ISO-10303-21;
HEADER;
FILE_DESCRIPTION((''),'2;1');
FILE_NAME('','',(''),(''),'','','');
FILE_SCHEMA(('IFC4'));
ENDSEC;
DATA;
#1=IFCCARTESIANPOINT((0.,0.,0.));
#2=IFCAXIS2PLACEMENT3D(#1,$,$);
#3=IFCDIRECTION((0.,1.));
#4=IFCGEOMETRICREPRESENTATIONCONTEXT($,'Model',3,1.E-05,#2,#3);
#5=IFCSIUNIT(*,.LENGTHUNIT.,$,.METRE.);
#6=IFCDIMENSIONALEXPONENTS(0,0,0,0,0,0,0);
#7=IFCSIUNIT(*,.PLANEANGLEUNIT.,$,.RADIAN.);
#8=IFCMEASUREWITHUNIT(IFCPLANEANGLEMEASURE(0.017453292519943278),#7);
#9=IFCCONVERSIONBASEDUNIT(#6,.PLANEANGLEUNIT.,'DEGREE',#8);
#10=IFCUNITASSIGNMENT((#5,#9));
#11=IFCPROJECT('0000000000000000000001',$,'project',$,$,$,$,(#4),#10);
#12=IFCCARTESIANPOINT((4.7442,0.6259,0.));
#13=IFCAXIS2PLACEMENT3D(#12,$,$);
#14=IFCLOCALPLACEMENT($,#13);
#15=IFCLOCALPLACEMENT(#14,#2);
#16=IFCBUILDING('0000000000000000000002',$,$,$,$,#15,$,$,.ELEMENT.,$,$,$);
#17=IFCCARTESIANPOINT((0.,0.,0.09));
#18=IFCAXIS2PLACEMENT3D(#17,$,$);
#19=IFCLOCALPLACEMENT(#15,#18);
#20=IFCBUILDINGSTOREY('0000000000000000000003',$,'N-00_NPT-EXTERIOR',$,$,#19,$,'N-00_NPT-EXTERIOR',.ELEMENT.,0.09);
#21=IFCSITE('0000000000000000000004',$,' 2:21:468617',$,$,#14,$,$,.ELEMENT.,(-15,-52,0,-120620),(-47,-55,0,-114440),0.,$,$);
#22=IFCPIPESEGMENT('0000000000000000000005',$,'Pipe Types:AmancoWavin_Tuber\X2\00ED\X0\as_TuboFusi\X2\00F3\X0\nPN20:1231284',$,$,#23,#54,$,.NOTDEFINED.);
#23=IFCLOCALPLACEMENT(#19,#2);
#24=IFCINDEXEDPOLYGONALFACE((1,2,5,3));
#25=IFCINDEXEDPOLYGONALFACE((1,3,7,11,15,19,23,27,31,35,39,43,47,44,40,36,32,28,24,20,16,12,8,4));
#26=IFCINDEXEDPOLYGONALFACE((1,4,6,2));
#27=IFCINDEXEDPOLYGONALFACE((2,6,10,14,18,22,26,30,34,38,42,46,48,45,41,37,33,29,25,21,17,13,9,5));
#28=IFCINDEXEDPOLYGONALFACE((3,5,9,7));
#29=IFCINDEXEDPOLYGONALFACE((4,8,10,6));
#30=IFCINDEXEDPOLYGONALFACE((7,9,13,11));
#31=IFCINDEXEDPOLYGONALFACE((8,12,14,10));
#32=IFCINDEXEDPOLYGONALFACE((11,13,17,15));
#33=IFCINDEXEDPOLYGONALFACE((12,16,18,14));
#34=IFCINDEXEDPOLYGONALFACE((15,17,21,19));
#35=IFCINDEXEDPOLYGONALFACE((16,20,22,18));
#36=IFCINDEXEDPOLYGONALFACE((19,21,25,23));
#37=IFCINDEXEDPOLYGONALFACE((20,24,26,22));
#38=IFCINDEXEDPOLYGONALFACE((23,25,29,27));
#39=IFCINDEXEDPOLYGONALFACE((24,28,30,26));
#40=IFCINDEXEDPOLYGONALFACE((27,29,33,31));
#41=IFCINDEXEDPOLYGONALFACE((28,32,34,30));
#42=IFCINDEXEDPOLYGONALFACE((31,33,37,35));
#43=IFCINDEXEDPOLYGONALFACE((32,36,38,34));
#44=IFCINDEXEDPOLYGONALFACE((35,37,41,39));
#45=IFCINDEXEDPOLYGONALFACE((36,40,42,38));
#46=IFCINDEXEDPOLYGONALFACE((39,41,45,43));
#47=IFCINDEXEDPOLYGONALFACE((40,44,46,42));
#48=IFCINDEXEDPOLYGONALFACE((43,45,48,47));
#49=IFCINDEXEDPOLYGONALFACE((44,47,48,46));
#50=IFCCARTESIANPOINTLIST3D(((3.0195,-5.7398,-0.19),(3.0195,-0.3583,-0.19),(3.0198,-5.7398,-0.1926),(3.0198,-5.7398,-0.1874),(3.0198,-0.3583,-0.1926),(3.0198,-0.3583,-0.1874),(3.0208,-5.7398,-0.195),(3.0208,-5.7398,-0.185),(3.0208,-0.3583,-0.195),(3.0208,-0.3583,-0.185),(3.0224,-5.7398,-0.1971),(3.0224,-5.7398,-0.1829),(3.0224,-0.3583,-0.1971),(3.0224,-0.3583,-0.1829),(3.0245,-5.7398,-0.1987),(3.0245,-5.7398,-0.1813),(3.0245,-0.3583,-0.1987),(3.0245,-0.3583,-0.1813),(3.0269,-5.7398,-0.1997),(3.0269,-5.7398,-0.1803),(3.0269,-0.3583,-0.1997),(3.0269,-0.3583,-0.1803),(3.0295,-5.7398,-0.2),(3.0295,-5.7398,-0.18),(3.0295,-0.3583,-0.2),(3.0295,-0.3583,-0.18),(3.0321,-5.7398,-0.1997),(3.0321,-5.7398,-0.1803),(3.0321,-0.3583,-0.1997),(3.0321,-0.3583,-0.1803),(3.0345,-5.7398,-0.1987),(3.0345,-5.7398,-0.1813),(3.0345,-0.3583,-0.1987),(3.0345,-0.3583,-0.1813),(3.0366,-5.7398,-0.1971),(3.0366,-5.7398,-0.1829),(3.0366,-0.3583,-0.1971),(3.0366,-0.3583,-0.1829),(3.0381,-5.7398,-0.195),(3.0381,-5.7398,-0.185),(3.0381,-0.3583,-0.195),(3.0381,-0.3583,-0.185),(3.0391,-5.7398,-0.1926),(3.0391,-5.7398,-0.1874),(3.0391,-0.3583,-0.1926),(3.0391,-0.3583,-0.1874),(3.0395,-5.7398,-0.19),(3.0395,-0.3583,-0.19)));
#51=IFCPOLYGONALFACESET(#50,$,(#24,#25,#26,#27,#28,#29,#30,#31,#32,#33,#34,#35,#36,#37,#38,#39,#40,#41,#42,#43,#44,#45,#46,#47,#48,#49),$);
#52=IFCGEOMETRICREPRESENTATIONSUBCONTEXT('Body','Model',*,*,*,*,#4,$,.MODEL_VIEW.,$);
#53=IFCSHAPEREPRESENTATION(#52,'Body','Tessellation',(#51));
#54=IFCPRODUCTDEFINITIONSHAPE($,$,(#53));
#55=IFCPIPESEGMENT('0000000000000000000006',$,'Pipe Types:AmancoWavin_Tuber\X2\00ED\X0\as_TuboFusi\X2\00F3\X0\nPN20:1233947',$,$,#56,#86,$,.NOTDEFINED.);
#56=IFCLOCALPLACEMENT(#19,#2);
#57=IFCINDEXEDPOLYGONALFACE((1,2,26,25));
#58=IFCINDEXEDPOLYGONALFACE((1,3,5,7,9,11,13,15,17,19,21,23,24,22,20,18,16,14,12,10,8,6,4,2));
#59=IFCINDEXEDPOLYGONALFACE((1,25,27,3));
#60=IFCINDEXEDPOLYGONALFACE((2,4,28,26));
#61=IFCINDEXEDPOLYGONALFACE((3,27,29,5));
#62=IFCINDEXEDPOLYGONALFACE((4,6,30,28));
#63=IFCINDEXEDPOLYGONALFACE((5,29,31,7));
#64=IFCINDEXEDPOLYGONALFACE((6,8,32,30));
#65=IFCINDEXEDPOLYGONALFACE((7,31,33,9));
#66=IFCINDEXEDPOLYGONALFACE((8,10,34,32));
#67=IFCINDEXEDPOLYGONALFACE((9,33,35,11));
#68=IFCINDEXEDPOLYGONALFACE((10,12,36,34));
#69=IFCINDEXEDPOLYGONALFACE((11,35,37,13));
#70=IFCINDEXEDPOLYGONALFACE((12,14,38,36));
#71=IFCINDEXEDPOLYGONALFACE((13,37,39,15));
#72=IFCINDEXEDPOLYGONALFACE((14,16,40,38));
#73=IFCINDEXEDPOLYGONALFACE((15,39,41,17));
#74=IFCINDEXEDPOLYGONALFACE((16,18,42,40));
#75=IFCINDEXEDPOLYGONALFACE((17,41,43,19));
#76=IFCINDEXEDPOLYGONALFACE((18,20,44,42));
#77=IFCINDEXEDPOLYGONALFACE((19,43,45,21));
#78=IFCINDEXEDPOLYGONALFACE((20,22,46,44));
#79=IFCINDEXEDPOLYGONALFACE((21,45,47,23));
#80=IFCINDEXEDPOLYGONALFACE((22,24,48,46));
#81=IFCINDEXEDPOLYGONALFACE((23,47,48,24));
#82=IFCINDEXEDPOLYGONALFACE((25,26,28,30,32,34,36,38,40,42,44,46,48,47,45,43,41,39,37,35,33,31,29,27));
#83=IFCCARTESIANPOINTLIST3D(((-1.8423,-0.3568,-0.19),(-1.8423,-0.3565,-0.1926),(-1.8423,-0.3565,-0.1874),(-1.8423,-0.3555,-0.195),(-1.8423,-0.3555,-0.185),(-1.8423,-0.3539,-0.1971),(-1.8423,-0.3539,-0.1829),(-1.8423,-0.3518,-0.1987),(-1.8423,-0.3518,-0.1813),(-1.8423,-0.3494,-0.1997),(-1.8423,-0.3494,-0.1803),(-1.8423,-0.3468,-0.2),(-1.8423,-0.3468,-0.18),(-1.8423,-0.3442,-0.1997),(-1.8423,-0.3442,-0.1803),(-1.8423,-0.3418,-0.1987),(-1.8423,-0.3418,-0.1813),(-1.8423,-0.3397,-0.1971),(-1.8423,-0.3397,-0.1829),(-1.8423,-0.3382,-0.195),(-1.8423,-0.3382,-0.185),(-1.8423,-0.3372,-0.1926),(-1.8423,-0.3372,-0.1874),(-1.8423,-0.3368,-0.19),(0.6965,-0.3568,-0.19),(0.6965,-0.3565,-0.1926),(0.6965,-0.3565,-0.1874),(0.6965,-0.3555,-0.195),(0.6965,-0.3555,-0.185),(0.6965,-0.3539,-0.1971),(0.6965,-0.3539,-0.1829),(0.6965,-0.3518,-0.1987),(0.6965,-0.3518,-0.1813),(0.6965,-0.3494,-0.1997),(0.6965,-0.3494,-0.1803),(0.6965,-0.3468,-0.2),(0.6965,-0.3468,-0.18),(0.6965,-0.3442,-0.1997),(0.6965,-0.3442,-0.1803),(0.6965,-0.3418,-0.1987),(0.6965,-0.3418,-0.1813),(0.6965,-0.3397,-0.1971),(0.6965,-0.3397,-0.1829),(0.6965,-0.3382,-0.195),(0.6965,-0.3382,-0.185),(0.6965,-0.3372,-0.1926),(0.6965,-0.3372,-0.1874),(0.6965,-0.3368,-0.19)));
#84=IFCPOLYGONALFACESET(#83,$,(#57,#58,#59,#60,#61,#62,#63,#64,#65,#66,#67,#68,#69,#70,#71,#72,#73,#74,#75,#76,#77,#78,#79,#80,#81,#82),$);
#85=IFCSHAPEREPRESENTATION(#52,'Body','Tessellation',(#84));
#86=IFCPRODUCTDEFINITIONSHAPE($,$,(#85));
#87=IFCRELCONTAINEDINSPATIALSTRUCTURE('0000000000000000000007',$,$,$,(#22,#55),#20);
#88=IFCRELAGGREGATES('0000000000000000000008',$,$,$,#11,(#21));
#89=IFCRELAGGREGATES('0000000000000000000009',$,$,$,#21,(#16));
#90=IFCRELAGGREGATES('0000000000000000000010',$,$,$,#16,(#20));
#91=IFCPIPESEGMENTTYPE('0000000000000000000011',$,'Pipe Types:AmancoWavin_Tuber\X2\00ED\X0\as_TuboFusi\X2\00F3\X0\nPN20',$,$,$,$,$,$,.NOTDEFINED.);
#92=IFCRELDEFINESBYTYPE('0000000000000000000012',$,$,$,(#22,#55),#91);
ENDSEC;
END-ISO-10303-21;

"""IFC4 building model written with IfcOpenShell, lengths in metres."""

from ifc_helpers import new_model, entity, si_unit, converted_unit, direction, frame, origin, place, context, subcontext, project, spatial, arc, indexed_curve, outline, extrude, type_object, element, save


model = new_model("IFC4")

# Units and contexts
model_context = context("Model", 3, precision=1e-05, world=origin(), true_north=direction((0.0, 1.0)))
body_context = subcontext(model_context, "Body", "Model", "MODEL_VIEW")
ifc_project = project(units=[si_unit("LENGTHUNIT", "METRE"), converted_unit("PLANEANGLEUNIT", "DEGREE", entity("IfcPlaneAngleMeasure", 0.017453292519943278), si_unit("PLANEANGLEUNIT", "RADIAN"), dimensions=[0, 0, 0, 0, 0, 0, 0])], contexts=[model_context])

# Site, building, storey
site_placement = place(None, frame((4.7442, 0.6259, 0.0)))
site = spatial("IfcSite", under=ifc_project, at=site_placement, Name=" 2:21:468617", CompositionType="ELEMENT", RefLatitude=(-15, -52, 0, -120620), RefLongitude=(-47, -55, 0, -114440), RefElevation=0.0)
building_placement = place(site_placement, origin())
building = spatial("IfcBuilding", under=site, at=building_placement, CompositionType="ELEMENT")
storey_placement = place(building_placement, frame((0.0, 0.0, 0.09)))
storey = spatial("IfcBuildingStorey", under=building, at=storey_placement, Name="N-00_NPT-EXTERIOR", LongName="N-00_NPT-EXTERIOR", CompositionType="ELEMENT", Elevation=0.09)

# Pipe segments
pipe_segment_type_1 = type_object("IfcPipeSegmentType", Name="Pipe Types:AmancoWavin_Tuberías_TuboFusiónPN20", PredefinedType="NOTDEFINED")
pipe_segment_1_placement = place(storey_placement, origin())
element("IfcPipeSegment", 1, at=pipe_segment_1_placement, inside=storey, type_object=pipe_segment_type_1, Name="Pipe Types:AmancoWavin_Tuberías_TuboFusiónPN20:1231284", PredefinedType="NOTDEFINED", context=body_context, shape_type="SweptSolid", body=[
    extrude(outline(indexed_curve([(0.01, 0.0), (0.0071, 0.0071), (0.0, 0.01), (-0.0071, 0.0071), (-0.01, 0.0), (-0.0071, -0.0071), (0.0, -0.01), (0.0071, -0.0071)], segments=[arc(1, 2, 3), arc(3, 4, 5), arc(5, 6, 7), arc(7, 8, 1)], self_intersect=False)), frame((3.0295, -5.7398, -0.19), z_axis=(0.0, 1.0, 0.0), x_axis=(-1.0, 0.0, 0.0)), (0.0, 0.0, 1.0), 5.3815),
])
pipe_segment_2_placement = place(storey_placement, origin())
element("IfcPipeSegment", 2, at=pipe_segment_2_placement, inside=storey, type_object=pipe_segment_type_1, Name="Pipe Types:AmancoWavin_Tuberías_TuboFusiónPN20:1233947", PredefinedType="NOTDEFINED", context=body_context, shape_type="SweptSolid", body=[
    extrude(outline(indexed_curve([(0.01, 0.0), (0.0071, 0.0071), (0.0, 0.01), (-0.0071, 0.0071), (-0.01, 0.0), (-0.0071, -0.0071), (0.0, -0.01), (0.0071, -0.0071)], segments=[arc(1, 2, 3), arc(3, 4, 5), arc(5, 6, 7), arc(7, 8, 1)], self_intersect=False)), frame((-1.8423, -0.3468, -0.19), z_axis=(1.0, 0.0, 0.0), x_axis=(0.0, -1.0, 0.0)), (0.0, 0.0, 1.0), 2.5387),
])

save(model, "model.ifc")
